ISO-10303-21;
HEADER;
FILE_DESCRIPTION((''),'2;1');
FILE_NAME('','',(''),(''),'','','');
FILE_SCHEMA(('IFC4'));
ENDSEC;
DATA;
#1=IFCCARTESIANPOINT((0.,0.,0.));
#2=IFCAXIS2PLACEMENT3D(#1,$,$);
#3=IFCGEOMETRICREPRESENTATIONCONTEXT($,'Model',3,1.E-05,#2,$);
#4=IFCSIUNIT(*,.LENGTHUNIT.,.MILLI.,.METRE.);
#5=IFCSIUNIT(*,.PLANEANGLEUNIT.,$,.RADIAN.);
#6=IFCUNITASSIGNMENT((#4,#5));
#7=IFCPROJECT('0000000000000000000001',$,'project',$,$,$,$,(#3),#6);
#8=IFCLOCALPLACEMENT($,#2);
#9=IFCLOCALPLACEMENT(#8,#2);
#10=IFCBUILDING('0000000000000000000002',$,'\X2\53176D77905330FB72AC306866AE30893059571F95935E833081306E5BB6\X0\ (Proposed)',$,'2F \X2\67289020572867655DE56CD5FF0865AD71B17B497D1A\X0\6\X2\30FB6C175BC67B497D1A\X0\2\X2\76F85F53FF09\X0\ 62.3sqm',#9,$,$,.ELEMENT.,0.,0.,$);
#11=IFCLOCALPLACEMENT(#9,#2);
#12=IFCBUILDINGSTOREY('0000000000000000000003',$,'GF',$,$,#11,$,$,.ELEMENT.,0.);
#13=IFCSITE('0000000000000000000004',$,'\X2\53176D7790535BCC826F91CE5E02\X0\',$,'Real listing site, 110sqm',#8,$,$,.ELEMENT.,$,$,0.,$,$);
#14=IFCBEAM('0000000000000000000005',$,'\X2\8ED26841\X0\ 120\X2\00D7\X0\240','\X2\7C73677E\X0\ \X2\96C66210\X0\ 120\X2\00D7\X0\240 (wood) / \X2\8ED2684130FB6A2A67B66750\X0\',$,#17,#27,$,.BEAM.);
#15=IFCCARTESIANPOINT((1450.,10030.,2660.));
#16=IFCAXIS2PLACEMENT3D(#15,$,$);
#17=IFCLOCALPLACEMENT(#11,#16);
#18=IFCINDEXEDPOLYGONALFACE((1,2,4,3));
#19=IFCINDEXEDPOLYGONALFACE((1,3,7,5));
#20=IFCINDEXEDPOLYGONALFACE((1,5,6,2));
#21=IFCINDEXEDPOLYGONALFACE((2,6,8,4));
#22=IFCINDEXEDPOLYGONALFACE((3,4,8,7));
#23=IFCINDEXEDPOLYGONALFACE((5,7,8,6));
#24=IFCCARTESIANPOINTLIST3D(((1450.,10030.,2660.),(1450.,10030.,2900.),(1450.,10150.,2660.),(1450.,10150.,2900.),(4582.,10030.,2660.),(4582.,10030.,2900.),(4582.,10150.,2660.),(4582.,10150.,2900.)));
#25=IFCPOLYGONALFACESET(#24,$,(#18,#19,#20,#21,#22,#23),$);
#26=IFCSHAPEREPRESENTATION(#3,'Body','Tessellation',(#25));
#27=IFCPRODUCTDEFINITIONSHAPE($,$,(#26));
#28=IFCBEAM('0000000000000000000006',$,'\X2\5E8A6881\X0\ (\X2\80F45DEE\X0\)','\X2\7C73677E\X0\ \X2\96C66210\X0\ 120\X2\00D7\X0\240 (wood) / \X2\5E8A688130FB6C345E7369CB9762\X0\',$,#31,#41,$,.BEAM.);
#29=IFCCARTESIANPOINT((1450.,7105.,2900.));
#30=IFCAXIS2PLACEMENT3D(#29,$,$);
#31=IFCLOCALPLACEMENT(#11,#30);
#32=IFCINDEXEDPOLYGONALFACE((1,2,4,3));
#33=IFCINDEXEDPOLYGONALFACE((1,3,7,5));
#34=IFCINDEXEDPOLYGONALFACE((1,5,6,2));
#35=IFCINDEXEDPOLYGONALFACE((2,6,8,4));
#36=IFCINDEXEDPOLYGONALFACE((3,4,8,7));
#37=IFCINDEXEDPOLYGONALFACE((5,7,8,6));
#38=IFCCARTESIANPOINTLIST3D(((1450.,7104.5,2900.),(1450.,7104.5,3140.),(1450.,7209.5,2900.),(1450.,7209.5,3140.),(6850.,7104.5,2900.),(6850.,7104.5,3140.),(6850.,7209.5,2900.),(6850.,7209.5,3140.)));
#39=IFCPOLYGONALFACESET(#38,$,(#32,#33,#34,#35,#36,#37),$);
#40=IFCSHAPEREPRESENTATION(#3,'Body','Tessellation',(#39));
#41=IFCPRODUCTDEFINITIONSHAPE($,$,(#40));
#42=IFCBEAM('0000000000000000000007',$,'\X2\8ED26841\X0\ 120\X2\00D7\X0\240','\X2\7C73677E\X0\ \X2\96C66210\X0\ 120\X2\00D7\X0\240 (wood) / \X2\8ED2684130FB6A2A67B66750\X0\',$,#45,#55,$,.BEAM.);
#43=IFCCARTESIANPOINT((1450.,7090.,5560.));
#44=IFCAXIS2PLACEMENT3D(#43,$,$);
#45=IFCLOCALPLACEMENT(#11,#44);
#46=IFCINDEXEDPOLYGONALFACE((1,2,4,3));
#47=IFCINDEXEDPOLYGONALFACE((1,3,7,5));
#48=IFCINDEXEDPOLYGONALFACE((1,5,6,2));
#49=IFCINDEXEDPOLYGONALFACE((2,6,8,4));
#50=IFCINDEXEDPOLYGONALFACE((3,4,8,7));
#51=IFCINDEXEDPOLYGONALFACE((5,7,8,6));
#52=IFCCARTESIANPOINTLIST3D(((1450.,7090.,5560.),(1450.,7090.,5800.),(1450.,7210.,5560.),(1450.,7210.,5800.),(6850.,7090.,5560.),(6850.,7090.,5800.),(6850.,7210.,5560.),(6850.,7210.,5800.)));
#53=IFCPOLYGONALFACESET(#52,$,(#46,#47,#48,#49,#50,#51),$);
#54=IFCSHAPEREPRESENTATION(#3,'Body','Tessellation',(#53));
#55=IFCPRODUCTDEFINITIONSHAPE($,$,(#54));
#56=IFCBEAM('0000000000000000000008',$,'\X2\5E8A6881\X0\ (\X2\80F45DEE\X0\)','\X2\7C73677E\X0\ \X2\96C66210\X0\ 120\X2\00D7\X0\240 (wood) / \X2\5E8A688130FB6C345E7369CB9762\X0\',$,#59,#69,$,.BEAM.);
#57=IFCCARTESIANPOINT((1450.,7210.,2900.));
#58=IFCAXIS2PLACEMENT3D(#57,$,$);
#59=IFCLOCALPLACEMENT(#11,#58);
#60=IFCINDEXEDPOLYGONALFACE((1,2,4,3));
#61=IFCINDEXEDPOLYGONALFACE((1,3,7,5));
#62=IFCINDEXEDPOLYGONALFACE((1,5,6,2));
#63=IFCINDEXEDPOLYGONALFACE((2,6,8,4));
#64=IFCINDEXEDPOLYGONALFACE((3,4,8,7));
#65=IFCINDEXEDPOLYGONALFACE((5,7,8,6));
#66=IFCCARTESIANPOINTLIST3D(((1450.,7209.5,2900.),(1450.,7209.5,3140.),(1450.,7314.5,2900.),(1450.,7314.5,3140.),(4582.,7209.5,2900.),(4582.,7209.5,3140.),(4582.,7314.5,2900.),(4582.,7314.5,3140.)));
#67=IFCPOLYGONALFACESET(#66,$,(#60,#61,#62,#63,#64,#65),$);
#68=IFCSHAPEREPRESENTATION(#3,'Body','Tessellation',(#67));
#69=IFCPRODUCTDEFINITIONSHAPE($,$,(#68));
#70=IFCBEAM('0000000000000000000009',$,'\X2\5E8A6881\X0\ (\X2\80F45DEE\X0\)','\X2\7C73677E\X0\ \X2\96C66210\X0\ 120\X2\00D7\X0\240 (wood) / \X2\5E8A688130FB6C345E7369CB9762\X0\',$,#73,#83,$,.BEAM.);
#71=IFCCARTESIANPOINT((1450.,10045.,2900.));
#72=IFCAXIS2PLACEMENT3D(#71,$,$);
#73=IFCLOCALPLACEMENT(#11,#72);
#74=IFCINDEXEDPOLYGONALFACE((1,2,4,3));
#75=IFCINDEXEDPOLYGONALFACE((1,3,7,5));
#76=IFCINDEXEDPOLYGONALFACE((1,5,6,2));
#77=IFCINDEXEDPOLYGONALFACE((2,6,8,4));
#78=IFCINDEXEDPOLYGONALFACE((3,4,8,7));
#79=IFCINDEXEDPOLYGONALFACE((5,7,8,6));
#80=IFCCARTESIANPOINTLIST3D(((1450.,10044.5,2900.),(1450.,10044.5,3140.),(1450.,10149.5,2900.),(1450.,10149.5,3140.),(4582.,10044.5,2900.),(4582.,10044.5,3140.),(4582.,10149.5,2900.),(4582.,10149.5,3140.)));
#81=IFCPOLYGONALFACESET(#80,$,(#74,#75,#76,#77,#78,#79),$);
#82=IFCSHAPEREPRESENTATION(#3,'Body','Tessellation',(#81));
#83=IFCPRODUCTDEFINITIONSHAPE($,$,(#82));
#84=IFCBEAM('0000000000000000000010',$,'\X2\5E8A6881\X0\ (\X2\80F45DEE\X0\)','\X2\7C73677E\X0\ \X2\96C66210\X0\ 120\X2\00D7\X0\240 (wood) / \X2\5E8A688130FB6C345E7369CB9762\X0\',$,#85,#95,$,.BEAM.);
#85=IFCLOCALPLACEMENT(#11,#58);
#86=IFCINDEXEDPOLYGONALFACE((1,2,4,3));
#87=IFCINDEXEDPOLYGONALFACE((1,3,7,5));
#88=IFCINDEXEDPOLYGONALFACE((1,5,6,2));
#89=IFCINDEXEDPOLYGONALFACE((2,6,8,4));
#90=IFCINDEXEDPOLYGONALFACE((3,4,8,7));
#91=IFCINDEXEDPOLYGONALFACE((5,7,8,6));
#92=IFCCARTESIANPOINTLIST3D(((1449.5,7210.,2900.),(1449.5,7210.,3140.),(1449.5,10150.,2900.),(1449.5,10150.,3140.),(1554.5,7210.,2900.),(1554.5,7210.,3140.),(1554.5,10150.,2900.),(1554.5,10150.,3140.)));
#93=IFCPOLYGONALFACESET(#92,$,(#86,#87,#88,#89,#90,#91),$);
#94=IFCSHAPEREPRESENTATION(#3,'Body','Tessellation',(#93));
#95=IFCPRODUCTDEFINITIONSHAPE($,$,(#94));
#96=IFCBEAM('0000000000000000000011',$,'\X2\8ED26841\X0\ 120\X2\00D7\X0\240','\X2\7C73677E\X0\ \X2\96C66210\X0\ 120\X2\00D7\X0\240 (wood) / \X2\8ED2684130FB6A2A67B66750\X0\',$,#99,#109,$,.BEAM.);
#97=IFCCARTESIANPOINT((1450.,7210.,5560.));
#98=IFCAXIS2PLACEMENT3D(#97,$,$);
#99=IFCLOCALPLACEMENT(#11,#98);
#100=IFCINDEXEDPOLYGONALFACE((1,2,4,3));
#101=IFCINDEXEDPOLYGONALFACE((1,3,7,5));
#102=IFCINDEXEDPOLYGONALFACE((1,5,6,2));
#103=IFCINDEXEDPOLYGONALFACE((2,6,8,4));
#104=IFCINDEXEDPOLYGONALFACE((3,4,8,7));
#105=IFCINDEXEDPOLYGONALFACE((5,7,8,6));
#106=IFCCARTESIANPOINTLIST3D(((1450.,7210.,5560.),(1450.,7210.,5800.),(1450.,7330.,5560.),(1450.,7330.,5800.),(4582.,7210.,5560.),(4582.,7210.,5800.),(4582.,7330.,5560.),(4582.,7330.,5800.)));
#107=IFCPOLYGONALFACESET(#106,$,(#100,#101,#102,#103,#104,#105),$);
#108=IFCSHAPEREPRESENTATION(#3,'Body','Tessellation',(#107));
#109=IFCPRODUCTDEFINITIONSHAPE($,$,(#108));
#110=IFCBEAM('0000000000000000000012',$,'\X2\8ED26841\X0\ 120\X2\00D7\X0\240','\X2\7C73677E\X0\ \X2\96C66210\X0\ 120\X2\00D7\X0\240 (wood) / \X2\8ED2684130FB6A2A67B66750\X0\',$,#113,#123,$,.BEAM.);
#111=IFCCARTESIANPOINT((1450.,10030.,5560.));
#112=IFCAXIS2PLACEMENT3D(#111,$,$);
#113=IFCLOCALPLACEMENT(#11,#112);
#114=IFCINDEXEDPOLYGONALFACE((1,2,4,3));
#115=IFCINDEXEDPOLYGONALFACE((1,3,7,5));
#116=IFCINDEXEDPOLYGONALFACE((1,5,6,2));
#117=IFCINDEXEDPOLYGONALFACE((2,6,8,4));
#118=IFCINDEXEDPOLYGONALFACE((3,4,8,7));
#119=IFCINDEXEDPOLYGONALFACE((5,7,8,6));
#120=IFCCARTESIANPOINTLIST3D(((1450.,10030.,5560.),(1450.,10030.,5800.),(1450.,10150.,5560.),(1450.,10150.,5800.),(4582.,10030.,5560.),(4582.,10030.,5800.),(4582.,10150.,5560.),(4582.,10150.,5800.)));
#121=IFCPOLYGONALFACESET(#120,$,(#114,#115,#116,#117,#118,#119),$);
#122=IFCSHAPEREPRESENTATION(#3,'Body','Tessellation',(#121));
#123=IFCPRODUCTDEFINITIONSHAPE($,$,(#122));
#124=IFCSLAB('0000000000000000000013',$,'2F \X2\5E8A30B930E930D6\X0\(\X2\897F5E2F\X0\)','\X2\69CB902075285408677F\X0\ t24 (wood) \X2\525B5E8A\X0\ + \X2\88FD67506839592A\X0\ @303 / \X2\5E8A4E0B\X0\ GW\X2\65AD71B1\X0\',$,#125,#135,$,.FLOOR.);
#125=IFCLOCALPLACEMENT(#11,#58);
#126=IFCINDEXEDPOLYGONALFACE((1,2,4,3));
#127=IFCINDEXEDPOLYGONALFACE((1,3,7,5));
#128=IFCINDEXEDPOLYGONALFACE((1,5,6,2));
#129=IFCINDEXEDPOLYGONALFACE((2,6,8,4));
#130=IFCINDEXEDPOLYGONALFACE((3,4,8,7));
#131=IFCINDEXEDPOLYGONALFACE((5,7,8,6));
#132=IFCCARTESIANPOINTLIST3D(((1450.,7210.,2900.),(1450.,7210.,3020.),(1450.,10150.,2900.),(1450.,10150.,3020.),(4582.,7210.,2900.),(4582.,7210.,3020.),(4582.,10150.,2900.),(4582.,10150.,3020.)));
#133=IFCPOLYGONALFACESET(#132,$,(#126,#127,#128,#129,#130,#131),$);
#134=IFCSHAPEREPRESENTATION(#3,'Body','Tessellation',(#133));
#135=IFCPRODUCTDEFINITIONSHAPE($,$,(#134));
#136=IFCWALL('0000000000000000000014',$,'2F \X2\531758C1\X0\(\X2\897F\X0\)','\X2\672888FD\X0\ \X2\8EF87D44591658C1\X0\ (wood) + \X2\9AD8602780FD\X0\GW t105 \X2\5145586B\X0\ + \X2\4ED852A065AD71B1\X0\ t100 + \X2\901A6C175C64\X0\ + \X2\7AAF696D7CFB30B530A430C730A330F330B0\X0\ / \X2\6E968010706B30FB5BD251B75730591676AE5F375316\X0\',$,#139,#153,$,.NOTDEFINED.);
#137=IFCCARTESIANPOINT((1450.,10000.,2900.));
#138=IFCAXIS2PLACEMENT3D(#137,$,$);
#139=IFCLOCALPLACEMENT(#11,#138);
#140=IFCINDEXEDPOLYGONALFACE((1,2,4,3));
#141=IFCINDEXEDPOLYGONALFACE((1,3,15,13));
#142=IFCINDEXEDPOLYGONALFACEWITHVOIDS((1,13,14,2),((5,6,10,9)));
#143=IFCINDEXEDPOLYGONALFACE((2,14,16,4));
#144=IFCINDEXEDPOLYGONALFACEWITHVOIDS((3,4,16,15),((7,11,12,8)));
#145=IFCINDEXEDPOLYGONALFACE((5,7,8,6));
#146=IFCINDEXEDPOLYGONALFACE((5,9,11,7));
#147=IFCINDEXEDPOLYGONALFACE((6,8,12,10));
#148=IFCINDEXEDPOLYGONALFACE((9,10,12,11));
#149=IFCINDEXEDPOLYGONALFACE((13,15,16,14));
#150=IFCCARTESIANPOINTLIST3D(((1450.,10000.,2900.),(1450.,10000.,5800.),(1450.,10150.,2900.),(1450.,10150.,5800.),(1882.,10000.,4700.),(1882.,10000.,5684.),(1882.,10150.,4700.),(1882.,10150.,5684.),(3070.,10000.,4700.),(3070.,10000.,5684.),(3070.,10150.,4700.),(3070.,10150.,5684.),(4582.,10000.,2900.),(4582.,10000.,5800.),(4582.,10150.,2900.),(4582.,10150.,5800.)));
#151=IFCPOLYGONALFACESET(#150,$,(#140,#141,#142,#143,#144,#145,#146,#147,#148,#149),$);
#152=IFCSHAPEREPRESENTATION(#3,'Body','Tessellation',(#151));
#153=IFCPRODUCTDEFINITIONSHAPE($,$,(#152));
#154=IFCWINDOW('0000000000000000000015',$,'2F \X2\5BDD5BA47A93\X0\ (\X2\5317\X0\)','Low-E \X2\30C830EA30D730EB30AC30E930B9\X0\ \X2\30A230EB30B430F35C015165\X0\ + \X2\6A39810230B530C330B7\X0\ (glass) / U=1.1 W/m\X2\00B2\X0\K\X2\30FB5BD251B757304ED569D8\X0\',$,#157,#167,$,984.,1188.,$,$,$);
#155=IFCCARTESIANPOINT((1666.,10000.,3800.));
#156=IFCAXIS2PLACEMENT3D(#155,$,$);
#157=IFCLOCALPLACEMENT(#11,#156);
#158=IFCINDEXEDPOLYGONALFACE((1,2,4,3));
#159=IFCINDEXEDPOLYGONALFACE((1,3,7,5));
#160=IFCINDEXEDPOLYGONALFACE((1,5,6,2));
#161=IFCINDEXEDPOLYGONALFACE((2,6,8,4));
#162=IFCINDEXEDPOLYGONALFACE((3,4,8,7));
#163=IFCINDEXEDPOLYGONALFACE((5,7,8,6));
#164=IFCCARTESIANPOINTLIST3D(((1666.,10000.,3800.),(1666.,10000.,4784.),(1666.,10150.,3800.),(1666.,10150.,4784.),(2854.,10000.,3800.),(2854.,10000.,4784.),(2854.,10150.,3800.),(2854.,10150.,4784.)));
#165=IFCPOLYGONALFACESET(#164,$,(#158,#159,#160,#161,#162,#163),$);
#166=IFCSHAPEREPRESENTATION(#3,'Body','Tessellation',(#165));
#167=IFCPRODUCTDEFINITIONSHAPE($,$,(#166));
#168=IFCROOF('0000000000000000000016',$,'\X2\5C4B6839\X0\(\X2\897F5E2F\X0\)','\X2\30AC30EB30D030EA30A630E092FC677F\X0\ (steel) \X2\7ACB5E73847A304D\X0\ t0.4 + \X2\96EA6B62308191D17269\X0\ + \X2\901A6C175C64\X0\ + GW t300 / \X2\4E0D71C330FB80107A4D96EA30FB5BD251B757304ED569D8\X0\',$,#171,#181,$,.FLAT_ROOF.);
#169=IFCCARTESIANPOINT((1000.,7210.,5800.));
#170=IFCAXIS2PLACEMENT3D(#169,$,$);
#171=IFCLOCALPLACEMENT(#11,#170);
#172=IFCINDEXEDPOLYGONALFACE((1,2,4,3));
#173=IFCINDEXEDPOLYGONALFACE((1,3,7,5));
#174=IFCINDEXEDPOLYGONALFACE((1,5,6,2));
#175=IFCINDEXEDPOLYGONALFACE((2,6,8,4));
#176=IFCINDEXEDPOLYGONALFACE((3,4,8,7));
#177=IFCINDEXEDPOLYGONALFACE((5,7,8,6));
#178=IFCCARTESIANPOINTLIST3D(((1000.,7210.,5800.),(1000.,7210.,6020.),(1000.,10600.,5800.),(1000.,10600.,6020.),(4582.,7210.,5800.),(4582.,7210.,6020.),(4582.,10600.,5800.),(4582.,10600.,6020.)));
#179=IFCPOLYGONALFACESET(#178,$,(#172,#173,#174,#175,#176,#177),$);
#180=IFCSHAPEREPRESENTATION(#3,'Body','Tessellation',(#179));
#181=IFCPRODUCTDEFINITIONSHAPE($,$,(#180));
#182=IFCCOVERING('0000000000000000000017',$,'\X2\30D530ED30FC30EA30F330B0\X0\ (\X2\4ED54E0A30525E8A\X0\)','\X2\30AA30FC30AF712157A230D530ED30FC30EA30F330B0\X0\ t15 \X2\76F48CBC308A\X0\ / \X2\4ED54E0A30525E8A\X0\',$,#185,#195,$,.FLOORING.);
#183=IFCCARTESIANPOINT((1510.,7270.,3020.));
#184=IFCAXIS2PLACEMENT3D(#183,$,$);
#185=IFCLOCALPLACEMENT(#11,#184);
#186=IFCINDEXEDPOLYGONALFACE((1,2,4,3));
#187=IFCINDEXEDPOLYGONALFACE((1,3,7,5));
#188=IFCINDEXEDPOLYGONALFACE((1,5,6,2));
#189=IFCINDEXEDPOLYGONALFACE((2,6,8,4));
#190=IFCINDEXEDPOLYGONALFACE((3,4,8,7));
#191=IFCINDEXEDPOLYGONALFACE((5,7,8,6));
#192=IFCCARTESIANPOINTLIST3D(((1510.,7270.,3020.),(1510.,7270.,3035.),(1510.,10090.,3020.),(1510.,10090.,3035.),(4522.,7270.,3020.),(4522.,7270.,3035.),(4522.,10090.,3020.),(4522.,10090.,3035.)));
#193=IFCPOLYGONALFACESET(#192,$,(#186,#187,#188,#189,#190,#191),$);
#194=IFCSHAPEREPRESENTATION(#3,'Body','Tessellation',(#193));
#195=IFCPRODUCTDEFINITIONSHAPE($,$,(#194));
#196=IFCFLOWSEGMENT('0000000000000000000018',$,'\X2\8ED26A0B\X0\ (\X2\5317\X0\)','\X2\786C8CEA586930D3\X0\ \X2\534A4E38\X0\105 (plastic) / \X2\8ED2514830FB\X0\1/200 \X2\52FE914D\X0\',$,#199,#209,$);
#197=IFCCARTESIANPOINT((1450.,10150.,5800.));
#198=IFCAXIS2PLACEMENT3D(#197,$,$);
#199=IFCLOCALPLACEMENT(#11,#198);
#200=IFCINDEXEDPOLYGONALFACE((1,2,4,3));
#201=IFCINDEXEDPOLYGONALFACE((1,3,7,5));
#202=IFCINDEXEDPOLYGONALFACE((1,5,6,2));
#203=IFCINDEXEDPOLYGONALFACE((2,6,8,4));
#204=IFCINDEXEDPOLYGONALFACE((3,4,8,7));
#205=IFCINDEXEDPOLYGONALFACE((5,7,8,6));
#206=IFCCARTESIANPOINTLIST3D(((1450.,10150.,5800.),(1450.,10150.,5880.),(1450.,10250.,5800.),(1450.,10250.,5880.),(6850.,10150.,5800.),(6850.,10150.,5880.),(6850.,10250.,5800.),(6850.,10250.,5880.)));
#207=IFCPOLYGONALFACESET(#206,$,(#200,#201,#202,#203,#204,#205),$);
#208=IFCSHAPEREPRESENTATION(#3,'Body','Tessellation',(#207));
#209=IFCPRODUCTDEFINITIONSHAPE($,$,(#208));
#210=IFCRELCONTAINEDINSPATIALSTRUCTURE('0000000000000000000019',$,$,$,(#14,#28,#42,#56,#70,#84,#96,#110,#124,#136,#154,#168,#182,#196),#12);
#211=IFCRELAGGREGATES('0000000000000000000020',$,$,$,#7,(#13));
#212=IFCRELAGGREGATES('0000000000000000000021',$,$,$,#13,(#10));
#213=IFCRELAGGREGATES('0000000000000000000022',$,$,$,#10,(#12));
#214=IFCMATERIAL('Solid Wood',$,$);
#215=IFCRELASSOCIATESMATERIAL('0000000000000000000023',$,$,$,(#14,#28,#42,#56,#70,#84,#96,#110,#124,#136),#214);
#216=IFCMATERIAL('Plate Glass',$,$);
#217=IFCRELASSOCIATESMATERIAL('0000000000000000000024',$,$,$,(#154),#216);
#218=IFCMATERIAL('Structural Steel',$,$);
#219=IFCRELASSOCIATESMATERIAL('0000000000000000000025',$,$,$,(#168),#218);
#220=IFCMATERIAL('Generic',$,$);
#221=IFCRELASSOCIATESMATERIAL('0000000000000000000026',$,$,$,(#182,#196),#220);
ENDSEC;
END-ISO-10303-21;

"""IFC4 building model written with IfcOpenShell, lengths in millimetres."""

from ifc_helpers import new_model, si_unit, frame, frame_2d, origin, place, context, project, spatial, rectangle, extrude, material, element, fill, save


model = new_model("IFC4")

# Units and contexts
model_context = context("Model", 3, precision=1e-05, world=origin())
ifc_project = project(units=[si_unit("LENGTHUNIT", "METRE", prefix="MILLI"), si_unit("PLANEANGLEUNIT", "RADIAN")], contexts=[model_context])

# Site, building, storey
site_placement = place(None, origin())
site = spatial("IfcSite", under=ifc_project, at=site_placement, Name="北海道富良野市", ObjectType="Real listing site, 110sqm", CompositionType="ELEMENT", RefElevation=0.0)
building_placement = place(site_placement, origin())
building = spatial("IfcBuilding", under=site, at=building_placement, Name="北海道・犬と暮らす土間広めの家 (Proposed)", ObjectType="2F 木造在来工法（断熱等級6・気密等級2相当） 62.3sqm", CompositionType="ELEMENT", ElevationOfRefHeight=0.0, ElevationOfTerrain=0.0)
storey_placement = place(building_placement, origin())
storey = spatial("IfcBuildingStorey", under=building, at=storey_placement, Name="GF", CompositionType="ELEMENT", Elevation=0.0)

# Shared definitions
ifc_material_1 = material(Name="Solid Wood")

# Beams
beam_1_placement = place(storey_placement, frame((1450.0, 10030.0, 2660.0)))
element("IfcBeam", 1, at=beam_1_placement, inside=storey, material=ifc_material_1, Name="軒桁 120×240", Description="米松 集成 120×240 (wood) / 軒桁・横架材", PredefinedType="BEAM", context=model_context, shape_type="SweptSolid", body=[
    extrude(rectangle(XDim=3132.0, YDim=120.0, at=frame_2d((1566.0, 60.0))), frame((1450.0, 10030.0, 2660.0)), (0.0, 0.0, 1.0), 240.0),
])
beam_2_placement = place(storey_placement, frame((1450.0, 7105.0, 2900.0)))
element("IfcBeam", 2, at=beam_2_placement, inside=storey, material=ifc_material_1, Name="床梁 (胴差)", Description="米松 集成 120×240 (wood) / 床梁・水平構面", PredefinedType="BEAM", context=model_context, shape_type="SweptSolid", body=[
    extrude(rectangle(XDim=5400.0, YDim=105.0, at=frame_2d((2700.0, 52.0))), frame((1450.0, 7105.0, 2900.0)), (0.0, 0.0, 1.0), 240.0),
])
beam_3_placement = place(storey_placement, frame((1450.0, 7090.0, 5560.0)))
element("IfcBeam", 3, at=beam_3_placement, inside=storey, material=ifc_material_1, Name="軒桁 120×240", Description="米松 集成 120×240 (wood) / 軒桁・横架材", PredefinedType="BEAM", context=model_context, shape_type="SweptSolid", body=[
    extrude(rectangle(XDim=5400.0, YDim=120.0, at=frame_2d((2700.0, 60.0))), frame((1450.0, 7090.0, 5560.0)), (0.0, 0.0, 1.0), 240.0),
])
beam_4_placement = place(storey_placement, frame((1450.0, 7210.0, 2900.0)))
element("IfcBeam", 4, at=beam_4_placement, inside=storey, material=ifc_material_1, Name="床梁 (胴差)", Description="米松 集成 120×240 (wood) / 床梁・水平構面", PredefinedType="BEAM", context=model_context, shape_type="SweptSolid", body=[
    extrude(rectangle(XDim=3132.0, YDim=105.0, at=frame_2d((1566.0, 52.0))), frame((1450.0, 7210.0, 2900.0)), (0.0, 0.0, 1.0), 240.0),
])
beam_5_placement = place(storey_placement, frame((1450.0, 10045.0, 2900.0)))
element("IfcBeam", 5, at=beam_5_placement, inside=storey, material=ifc_material_1, Name="床梁 (胴差)", Description="米松 集成 120×240 (wood) / 床梁・水平構面", PredefinedType="BEAM", context=model_context, shape_type="SweptSolid", body=[
    extrude(rectangle(XDim=3132.0, YDim=105.0, at=frame_2d((1566.0, 52.0))), frame((1450.0, 10045.0, 2900.0)), (0.0, 0.0, 1.0), 240.0),
])
beam_6_placement = place(storey_placement, frame((1450.0, 7210.0, 2900.0)))
element("IfcBeam", 6, at=beam_6_placement, inside=storey, material=ifc_material_1, Name="床梁 (胴差)", Description="米松 集成 120×240 (wood) / 床梁・水平構面", PredefinedType="BEAM", context=model_context, shape_type="SweptSolid", body=[
    extrude(rectangle(XDim=105.0, YDim=2940.0, at=frame_2d((52.0, 1470.0))), frame((1450.0, 7210.0, 2900.0)), (0.0, 0.0, 1.0), 240.0),
])
beam_7_placement = place(storey_placement, frame((1450.0, 7210.0, 5560.0)))
element("IfcBeam", 7, at=beam_7_placement, inside=storey, material=ifc_material_1, Name="軒桁 120×240", Description="米松 集成 120×240 (wood) / 軒桁・横架材", PredefinedType="BEAM", context=model_context, shape_type="SweptSolid", body=[
    extrude(rectangle(XDim=3132.0, YDim=120.0, at=frame_2d((1566.0, 60.0))), frame((1450.0, 7210.0, 5560.0)), (0.0, 0.0, 1.0), 240.0),
])
beam_8_placement = place(storey_placement, frame((1450.0, 10030.0, 5560.0)))
element("IfcBeam", 8, at=beam_8_placement, inside=storey, material=ifc_material_1, Name="軒桁 120×240", Description="米松 集成 120×240 (wood) / 軒桁・横架材", PredefinedType="BEAM", context=model_context, shape_type="SweptSolid", body=[
    extrude(rectangle(XDim=3132.0, YDim=120.0, at=frame_2d((1566.0, 60.0))), frame((1450.0, 10030.0, 5560.0)), (0.0, 0.0, 1.0), 240.0),
])

# Slab
slab_placement = place(storey_placement, frame((1450.0, 7210.0, 2900.0)))
element("IfcSlab", 9, at=slab_placement, inside=storey, material=ifc_material_1, Name="2F 床スラブ(西帯)", Description="構造用合板 t24 (wood) 剛床 + 製材根太 @303 / 床下 GW断熱", PredefinedType="FLOOR", context=model_context, shape_type="SweptSolid", body=[
    extrude(rectangle(XDim=3132.0, YDim=2940.0, at=frame_2d((1566.0, 1470.0))), frame((1450.0, 7210.0, 2900.0)), (0.0, 0.0, 1.0), 120.0),
])

# Wall, opening, window
wall_1_placement = place(storey_placement, frame((1450.0, 10000.0, 2900.0)))
wall_1 = element("IfcWall", 10, at=wall_1_placement, inside=storey, material=ifc_material_1, Name="2F 北壁(西)", Description="木製 軸組外壁 (wood) + 高性能GW t105 充填 + 付加断熱 t100 + 通気層 + 窯業系サイディング / 準耐火・寒冷地外皮強化", PredefinedType="NOTDEFINED", context=model_context, shape_type="SweptSolid", body=[
    extrude(rectangle(XDim=3132.0, YDim=150.0, at=frame_2d((1566.0, 75.0))), frame((1450.0, 10000.0, 2900.0)), (0.0, 0.0, 1.0), 2900.0),
])
opening_placement = place(storey_placement, frame((1666.0, 10000.0, 3800.0)))
opening = element("IfcOpeningElement", 11, at=opening_placement, cuts=wall_1, PredefinedType="NOTDEFINED", context=model_context, shape_type="SweptSolid", body=[
    extrude(rectangle(XDim=1188.0, YDim=150.0, at=frame_2d((594.0, 75.0))), frame((1666.0, 10000.0, 3800.0)), (0.0, 0.0, 1.0), 984.0),
])
ifc_material_2 = material(Name="Plate Glass")
window_placement = place(storey_placement, frame((1666.0, 10000.0, 3800.0)))
window = element("IfcWindow", 12, at=window_placement, inside=storey, material=ifc_material_2, Name="2F 寝室窓 (北)", Description="Low-E トリプルガラス アルゴン封入 + 樹脂サッシ (glass) / U=1.1 W/m²K・寒冷地仕様", OverallHeight=984.0, OverallWidth=1188.0, context=model_context, shape_type="SweptSolid", body=[
    extrude(rectangle(XDim=1188.0, YDim=150.0, at=frame_2d((594.0, 75.0))), frame((1666.0, 10000.0, 3800.0)), (0.0, 0.0, 1.0), 984.0),
])
fill(opening, window)

# Roof
ifc_material_3 = material(Name="Structural Steel")
for number, where, name in (
    (13, (1000.0, 7210.0, 5800.0), "屋根(西帯)"),
):
    element("IfcRoof", number, at=place(storey_placement, frame(where)), inside=storey, material=ifc_material_3, Name=name, Description="ガルバリウム鋼板 (steel) 立平葺き t0.4 + 雪止め金物 + 通気層 + GW t300 / 不燃・耐積雪・寒冷地仕様", PredefinedType="FLAT_ROOF", context=model_context, shape_type="SweptSolid", body=[
        extrude(rectangle(XDim=3582.0, YDim=3390.0, at=frame_2d((1791.0, 1695.0))), frame((1000.0, 7210.0, 5800.0)), (0.0, 0.0, 1.0), 220.0),
    ])

# Covering
ifc_material_4 = material(Name="Generic")
covering_placement = place(storey_placement, frame((1510.0, 7270.0, 3020.0)))
element("IfcCovering", 14, at=covering_placement, inside=storey, material=ifc_material_4, Name="フローリング (仕上げ床)", Description="オーク無垢フローリング t15 直貼り / 仕上げ床", PredefinedType="FLOORING", context=model_context, shape_type="SweptSolid", body=[
    extrude(rectangle(XDim=3012.0, YDim=2820.0, at=frame_2d((1506.0, 1410.0))), frame((1510.0, 7270.0, 3020.0)), (0.0, 0.0, 1.0), 15.0),
])

# Flow segment
flow_segment_placement = place(storey_placement, frame((1450.0, 10150.0, 5800.0)))
element("IfcFlowSegment", 15, at=flow_segment_placement, inside=storey, material=ifc_material_4, Name="軒樋 (北)", Description="硬質塩ビ 半丸105 (plastic) / 軒先・1/200 勾配", context=model_context, shape_type="SweptSolid", body=[
    extrude(rectangle(XDim=5400.0, YDim=100.0, at=frame_2d((2700.0, 50.0))), frame((1450.0, 10150.0, 5800.0)), (0.0, 0.0, 1.0), 80.0),
])

save(model, "model.ifc")
